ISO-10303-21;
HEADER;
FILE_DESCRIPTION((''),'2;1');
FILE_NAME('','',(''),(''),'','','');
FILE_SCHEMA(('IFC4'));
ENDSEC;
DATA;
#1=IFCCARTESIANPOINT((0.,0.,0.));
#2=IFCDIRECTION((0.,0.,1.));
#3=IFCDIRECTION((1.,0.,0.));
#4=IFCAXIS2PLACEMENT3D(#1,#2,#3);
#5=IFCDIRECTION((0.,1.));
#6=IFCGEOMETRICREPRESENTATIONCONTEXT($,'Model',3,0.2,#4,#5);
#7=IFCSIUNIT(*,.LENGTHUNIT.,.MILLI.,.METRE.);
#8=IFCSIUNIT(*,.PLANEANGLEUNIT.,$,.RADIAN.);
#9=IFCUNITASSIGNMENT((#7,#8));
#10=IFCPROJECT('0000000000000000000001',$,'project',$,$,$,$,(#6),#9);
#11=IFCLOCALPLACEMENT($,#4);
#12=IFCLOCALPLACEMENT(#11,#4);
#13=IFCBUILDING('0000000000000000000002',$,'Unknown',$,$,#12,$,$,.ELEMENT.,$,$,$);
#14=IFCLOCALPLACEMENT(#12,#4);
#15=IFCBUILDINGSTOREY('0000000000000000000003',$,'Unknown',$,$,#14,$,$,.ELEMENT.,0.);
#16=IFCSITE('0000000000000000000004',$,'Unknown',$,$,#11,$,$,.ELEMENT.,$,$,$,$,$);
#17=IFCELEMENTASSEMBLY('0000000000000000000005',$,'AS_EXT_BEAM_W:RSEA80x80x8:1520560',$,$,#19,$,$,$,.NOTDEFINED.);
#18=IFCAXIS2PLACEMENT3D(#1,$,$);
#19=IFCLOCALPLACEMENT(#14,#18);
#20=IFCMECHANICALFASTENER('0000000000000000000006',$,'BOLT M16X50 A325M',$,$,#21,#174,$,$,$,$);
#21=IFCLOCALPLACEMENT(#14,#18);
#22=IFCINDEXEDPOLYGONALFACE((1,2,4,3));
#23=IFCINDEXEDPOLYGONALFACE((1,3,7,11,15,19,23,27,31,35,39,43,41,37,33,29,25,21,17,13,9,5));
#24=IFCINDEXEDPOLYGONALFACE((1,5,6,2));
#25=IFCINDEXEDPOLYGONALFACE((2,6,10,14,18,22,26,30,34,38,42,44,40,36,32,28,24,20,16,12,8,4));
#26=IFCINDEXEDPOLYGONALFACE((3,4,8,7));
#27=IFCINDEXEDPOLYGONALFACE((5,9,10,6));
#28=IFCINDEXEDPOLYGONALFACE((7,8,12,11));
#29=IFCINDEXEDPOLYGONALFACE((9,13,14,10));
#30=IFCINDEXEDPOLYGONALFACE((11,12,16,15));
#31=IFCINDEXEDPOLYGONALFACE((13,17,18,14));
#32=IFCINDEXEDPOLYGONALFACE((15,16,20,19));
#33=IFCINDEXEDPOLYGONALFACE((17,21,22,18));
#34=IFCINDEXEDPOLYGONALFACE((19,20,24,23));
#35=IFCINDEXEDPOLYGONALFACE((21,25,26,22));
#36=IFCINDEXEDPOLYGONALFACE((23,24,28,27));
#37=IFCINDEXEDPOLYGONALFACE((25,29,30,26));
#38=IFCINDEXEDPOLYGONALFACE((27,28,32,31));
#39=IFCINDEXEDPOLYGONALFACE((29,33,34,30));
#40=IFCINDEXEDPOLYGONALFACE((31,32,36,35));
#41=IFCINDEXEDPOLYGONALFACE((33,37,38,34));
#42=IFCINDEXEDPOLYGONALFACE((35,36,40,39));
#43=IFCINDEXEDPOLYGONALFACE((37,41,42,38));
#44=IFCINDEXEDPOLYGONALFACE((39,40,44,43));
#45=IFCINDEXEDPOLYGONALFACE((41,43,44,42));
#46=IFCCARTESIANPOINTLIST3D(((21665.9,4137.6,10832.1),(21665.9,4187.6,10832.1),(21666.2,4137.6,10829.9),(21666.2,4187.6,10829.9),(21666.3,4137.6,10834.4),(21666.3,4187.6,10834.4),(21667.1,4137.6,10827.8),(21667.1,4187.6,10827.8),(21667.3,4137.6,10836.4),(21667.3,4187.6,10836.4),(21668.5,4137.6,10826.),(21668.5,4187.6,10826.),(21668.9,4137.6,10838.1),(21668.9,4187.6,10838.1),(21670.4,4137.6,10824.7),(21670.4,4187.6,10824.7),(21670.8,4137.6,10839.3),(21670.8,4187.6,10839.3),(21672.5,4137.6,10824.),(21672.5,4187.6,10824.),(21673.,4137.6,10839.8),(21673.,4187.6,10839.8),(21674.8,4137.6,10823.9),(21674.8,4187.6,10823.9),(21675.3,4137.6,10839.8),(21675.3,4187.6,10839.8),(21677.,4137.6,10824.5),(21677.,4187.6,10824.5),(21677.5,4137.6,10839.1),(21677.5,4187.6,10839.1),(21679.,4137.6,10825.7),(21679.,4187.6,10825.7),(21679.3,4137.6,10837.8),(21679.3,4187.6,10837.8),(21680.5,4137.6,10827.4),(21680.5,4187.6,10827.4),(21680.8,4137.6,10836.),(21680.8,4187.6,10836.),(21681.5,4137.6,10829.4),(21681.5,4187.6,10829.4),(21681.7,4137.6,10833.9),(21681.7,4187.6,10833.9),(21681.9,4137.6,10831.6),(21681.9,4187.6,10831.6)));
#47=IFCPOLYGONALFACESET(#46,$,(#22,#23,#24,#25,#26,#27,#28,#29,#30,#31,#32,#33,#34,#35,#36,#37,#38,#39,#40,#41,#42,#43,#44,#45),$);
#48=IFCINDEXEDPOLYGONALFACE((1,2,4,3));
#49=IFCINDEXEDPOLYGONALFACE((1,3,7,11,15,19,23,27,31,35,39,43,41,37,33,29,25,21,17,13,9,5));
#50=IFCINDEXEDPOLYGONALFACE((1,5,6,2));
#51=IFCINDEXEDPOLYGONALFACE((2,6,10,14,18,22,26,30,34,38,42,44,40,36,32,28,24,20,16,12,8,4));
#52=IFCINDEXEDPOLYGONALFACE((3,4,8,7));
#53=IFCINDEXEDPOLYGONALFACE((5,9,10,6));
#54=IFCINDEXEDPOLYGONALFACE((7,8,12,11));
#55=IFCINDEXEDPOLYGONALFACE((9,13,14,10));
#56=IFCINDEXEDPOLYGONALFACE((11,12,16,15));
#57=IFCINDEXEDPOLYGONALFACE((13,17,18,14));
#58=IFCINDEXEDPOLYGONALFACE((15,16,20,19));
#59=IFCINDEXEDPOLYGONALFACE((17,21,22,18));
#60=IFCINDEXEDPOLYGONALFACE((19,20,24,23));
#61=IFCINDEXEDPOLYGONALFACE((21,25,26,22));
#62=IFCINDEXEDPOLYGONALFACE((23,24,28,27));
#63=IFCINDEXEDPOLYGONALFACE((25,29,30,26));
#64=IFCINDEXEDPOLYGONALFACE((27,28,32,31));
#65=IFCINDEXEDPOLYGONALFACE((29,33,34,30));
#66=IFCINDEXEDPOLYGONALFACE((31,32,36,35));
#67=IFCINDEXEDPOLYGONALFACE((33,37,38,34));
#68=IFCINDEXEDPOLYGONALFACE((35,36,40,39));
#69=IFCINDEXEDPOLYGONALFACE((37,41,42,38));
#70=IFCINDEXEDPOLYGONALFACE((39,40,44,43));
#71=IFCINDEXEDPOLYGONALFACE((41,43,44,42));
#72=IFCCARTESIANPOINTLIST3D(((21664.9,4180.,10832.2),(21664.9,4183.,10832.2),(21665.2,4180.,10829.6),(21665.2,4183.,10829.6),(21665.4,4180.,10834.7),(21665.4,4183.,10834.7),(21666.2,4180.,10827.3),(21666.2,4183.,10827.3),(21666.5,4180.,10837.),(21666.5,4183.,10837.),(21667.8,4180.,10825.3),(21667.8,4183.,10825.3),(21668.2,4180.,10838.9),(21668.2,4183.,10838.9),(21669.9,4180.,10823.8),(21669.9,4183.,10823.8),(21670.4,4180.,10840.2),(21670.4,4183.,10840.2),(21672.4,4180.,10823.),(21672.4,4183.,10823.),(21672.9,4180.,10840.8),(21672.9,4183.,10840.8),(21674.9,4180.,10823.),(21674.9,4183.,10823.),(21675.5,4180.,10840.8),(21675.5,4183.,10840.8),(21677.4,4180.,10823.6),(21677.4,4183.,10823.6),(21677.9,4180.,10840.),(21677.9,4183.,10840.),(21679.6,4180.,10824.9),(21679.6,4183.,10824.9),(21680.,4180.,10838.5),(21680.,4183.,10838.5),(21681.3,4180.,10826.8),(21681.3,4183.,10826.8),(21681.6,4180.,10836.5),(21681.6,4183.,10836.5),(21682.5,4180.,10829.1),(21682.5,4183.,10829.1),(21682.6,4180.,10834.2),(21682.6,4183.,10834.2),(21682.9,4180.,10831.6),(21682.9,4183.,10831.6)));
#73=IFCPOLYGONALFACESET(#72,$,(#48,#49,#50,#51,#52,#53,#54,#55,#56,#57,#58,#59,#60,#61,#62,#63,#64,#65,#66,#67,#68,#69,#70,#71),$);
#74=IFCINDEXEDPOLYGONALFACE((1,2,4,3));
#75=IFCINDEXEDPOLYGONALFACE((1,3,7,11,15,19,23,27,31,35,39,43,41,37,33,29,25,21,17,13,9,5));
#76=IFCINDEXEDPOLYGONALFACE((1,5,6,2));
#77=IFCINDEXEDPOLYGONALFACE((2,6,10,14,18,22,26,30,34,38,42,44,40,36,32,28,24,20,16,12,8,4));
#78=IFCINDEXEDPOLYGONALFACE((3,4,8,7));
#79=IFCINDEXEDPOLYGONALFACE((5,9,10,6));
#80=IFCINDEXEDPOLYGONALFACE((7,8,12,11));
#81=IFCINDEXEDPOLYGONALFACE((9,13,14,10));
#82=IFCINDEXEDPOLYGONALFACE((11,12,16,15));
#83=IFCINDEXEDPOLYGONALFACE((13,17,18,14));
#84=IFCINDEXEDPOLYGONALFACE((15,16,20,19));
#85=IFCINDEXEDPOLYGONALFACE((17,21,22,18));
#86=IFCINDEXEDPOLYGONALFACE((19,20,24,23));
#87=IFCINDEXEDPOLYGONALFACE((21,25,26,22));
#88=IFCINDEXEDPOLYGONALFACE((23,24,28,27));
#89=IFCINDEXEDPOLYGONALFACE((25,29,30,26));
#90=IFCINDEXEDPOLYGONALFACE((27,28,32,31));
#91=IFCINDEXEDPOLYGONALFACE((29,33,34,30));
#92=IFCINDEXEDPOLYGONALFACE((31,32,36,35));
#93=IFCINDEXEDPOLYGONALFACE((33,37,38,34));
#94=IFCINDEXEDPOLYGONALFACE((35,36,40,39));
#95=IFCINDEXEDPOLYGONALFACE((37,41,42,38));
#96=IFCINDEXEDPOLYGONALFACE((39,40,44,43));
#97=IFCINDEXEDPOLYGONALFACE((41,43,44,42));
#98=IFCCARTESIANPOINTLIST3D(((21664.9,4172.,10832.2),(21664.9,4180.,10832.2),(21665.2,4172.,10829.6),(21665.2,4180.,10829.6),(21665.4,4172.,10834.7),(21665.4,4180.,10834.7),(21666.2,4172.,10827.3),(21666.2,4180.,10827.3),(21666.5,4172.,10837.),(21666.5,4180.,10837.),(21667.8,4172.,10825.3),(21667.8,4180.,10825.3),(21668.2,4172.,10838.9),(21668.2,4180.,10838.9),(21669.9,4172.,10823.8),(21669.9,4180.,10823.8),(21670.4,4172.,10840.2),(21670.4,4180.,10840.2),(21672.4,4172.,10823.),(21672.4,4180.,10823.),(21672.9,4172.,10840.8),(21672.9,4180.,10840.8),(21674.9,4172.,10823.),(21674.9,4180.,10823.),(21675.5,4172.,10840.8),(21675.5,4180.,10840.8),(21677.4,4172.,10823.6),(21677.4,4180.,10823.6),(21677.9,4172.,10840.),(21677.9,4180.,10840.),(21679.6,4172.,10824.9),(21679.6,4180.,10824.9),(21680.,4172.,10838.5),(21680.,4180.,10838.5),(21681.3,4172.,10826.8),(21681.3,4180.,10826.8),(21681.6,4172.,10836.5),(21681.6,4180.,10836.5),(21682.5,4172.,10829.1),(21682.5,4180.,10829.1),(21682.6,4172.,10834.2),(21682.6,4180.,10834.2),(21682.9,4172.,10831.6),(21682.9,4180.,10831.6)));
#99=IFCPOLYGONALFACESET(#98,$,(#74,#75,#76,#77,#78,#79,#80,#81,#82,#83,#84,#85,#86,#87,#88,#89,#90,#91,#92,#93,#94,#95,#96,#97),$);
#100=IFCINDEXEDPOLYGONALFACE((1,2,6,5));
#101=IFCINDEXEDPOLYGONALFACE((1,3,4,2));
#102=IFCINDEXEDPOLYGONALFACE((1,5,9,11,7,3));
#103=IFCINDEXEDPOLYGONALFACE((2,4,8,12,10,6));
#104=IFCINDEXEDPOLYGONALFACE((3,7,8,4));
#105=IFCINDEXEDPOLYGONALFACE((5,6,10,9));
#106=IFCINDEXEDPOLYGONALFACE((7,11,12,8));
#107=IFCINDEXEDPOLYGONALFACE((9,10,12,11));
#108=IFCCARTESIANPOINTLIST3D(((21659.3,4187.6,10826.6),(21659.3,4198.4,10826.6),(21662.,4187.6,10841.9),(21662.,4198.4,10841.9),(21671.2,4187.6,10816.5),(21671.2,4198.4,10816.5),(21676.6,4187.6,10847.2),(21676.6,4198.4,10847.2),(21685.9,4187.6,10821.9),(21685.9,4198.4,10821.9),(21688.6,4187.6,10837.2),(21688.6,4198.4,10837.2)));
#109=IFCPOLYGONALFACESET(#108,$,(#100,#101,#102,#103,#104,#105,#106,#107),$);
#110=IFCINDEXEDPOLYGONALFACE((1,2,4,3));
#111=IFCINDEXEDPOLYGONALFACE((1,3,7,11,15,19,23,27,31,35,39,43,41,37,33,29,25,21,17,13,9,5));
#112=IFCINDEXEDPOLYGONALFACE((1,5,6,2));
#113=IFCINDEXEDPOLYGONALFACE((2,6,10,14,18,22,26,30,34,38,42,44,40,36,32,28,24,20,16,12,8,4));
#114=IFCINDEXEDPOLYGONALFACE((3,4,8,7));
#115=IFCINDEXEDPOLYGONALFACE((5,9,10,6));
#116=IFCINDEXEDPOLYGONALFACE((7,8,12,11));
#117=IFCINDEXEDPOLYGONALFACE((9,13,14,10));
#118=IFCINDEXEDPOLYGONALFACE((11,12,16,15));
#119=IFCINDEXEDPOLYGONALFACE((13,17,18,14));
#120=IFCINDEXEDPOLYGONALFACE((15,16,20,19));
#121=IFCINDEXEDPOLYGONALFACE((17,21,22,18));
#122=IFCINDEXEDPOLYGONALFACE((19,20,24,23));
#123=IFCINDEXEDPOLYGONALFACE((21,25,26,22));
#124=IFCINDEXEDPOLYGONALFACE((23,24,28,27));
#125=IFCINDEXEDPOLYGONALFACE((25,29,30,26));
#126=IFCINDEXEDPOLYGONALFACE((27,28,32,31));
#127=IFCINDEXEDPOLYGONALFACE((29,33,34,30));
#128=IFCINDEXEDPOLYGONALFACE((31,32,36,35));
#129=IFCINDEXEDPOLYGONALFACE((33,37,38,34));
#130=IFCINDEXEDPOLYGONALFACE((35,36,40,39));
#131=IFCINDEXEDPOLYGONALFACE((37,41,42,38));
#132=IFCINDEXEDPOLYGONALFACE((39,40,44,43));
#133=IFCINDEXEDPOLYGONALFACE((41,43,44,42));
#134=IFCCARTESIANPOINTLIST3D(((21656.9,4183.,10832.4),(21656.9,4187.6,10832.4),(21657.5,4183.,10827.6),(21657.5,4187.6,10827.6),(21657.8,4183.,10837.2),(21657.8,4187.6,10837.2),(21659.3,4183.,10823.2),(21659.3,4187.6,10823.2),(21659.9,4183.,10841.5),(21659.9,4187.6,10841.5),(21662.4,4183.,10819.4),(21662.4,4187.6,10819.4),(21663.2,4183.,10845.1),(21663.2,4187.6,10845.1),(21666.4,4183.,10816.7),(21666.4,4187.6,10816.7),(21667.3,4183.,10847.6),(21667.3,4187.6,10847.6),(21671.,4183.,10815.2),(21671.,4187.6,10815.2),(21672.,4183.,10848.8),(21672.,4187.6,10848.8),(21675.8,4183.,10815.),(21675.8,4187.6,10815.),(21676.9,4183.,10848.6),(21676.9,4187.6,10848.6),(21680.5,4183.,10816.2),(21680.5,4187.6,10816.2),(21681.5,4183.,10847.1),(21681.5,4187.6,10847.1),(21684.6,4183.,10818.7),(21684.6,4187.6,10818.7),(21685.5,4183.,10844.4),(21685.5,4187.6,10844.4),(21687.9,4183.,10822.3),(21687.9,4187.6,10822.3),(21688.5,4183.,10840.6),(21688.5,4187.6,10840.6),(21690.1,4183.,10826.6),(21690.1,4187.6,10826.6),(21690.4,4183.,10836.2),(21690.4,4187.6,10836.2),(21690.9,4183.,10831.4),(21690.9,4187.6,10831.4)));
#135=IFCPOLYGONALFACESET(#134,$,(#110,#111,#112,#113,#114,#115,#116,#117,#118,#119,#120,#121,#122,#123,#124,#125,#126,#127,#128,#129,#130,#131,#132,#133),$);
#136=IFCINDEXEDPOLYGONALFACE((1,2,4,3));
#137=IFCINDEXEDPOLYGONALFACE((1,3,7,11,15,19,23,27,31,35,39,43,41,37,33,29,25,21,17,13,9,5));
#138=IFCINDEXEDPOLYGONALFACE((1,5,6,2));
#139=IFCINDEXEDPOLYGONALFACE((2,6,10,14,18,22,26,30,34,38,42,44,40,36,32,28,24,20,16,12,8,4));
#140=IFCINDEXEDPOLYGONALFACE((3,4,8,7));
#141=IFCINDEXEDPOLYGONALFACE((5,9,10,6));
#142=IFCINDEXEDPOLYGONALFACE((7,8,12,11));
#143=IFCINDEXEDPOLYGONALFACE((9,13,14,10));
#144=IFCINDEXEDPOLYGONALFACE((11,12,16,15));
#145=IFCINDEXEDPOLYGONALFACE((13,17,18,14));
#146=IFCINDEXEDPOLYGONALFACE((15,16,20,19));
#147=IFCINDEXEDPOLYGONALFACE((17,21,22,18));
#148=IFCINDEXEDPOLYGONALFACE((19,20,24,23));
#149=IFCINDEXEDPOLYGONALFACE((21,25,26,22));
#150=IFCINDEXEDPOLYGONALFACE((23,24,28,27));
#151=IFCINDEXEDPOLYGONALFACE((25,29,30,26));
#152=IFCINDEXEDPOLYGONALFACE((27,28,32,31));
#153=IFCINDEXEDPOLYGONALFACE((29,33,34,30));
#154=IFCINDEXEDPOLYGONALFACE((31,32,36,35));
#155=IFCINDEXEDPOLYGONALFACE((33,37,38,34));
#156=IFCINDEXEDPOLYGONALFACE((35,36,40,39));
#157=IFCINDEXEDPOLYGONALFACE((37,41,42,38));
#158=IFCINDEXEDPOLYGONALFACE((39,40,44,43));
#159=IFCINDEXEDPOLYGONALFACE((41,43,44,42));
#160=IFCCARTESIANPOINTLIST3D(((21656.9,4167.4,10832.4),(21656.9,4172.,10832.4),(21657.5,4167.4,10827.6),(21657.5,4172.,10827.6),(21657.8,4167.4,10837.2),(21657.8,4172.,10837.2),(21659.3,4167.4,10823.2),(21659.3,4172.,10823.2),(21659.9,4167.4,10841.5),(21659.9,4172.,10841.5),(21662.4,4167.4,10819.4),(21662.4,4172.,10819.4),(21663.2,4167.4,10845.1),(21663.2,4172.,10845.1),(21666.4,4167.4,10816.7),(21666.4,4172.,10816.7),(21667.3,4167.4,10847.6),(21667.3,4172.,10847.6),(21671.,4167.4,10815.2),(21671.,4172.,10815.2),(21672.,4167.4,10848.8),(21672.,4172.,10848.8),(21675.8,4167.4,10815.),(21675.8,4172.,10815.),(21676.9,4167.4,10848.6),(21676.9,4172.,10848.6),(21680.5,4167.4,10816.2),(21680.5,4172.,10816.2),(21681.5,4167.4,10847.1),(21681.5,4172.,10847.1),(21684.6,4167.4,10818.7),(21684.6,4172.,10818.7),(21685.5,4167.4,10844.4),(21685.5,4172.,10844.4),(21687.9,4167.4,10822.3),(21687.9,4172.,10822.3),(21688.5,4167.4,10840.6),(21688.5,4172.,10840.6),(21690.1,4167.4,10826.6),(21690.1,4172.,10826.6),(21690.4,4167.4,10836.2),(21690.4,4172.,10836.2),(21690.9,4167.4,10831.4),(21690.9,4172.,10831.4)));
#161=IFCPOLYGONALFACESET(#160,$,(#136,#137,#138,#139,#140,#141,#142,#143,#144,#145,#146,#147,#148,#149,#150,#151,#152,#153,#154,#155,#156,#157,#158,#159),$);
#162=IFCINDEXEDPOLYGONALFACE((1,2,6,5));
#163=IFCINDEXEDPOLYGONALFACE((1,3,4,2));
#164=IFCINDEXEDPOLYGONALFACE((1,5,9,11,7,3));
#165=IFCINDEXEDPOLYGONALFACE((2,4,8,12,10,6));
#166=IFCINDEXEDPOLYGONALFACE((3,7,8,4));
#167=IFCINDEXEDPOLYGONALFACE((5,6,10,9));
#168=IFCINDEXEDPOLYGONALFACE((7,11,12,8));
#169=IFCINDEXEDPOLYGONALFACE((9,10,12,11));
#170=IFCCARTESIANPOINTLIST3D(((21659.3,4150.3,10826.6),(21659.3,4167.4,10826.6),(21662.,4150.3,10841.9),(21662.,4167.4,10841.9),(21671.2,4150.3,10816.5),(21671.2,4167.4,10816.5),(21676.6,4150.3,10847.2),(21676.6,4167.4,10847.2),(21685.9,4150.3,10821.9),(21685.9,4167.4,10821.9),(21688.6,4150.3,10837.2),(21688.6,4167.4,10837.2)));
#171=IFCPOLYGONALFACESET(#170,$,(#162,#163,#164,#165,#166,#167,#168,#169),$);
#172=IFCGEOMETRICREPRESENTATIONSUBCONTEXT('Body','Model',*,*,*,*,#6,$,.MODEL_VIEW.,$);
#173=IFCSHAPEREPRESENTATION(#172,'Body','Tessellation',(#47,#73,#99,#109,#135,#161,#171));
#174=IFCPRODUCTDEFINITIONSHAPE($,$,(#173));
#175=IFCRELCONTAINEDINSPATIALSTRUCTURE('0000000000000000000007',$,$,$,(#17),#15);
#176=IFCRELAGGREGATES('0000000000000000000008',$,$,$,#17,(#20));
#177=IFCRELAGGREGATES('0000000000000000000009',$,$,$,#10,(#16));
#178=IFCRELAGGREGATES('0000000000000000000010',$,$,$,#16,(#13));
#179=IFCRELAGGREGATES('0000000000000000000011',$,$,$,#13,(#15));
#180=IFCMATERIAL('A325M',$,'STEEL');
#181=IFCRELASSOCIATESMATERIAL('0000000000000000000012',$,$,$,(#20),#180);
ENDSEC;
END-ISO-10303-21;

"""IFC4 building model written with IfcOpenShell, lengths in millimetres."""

from ifc_helpers import new_model, si_unit, direction, frame, origin_with_axes, place, context, subcontext, project, spatial, line, arc, indexed_curve, outline, extrude, source, transform, mapped, material, element, aggregate, save


model = new_model("IFC4")

# Units and contexts
model_context = context("Model", 3, precision=0.2, world=origin_with_axes(), true_north=direction((0.0, 1.0)))
body_context = subcontext(model_context, "Body", "Model", "MODEL_VIEW")
ifc_project = project(units=[si_unit("LENGTHUNIT", "METRE", prefix="MILLI"), si_unit("PLANEANGLEUNIT", "RADIAN")], contexts=[model_context])

# Site, building, storey
site_placement = place(None, origin_with_axes())
site = spatial("IfcSite", under=ifc_project, at=site_placement, Name="Unknown", CompositionType="ELEMENT")
building_placement = place(site_placement, origin_with_axes())
building = spatial("IfcBuilding", under=site, at=building_placement, Name="Unknown", CompositionType="ELEMENT")
storey_placement = place(building_placement, origin_with_axes())
storey = spatial("IfcBuildingStorey", under=building, at=storey_placement, Name="Unknown", CompositionType="ELEMENT", Elevation=0.0)

# Shared definitions
ifc_material_1 = material(Name="A325M", Category="STEEL")
shared_shape = source(origin_with_axes(), body_context, "Body", "SweptSolid", [
    extrude(outline(indexed_curve([(8.0, 0.0), (0.0, 8.0), (-8.0, 0.0), (0.0, -8.0)], segments=[arc(1, 2, 3), arc(3, 4, 1)])), frame((0.0, 0.0, 15.6), z_axis=(0.0, 0.0, -1.0), x_axis=(0.0, 1.0, 0.0)), (0.0, 0.0, 1.0), 50.0),
    extrude(outline(indexed_curve([(9.0, 0.0), (0.0, 9.0), (-9.0, 0.0), (0.0, -9.0)], segments=[arc(1, 2, 3), arc(3, 4, 1)])), frame((0.0, 0.0, 11.0), z_axis=(0.0, 0.0, -1.0), x_axis=(0.0, 1.0, 0.0)), (0.0, 0.0, 1.0), 3.0),
    extrude(outline(indexed_curve([(9.0, 0.0), (0.0, 9.0), (-9.0, 0.0), (0.0, -9.0)], segments=[arc(1, 2, 3), arc(3, 4, 1)])), frame((0.0, 0.0, 8.0), z_axis=(0.0, 0.0, -1.0), x_axis=(0.0, 1.0, 0.0)), (0.0, 0.0, 1.0), 8.0),
    extrude(outline(indexed_curve([(15.6, 0.0), (7.8, 13.5), (-7.8, 13.5), (-15.6, 0.0), (-7.8, -13.5), (7.8, -13.5)], segments=[line(1, 2, 3, 4, 5, 6, 1)])), frame((0.0, 0.0, 26.4), z_axis=(0.0, 0.0, -1.0), x_axis=(0.0, 1.0, 0.0)), (0.0, 0.0, 1.0), 10.8),
    extrude(outline(indexed_curve([(17.0, 0.0), (0.0, 17.0), (-17.0, 0.0), (0.0, -17.0)], segments=[arc(1, 2, 3), arc(3, 4, 1)])), frame((0.0, 0.0, 15.6), z_axis=(0.0, 0.0, -1.0), x_axis=(0.0, 1.0, 0.0)), (0.0, 0.0, 1.0), 4.6),
    extrude(outline(indexed_curve([(17.0, 0.0), (0.0, 17.0), (-17.0, 0.0), (0.0, -17.0)], segments=[arc(1, 2, 3), arc(3, 4, 1)])), frame((0.0, 0.0, 0.0), z_axis=(0.0, 0.0, -1.0), x_axis=(0.0, 1.0, 0.0)), (0.0, 0.0, 1.0), 4.6),
    extrude(outline(indexed_curve([(15.6, 0.0), (7.8, 13.5), (-7.8, 13.5), (-15.6, 0.0), (-7.8, -13.5), (7.8, -13.5)], segments=[line(1, 2, 3, 4, 5, 6, 1)])), frame((0.0, 0.0, -4.6), z_axis=(0.0, 0.0, -1.0), x_axis=(0.0, 1.0, 0.0)), (0.0, 0.0, 1.0), 17.1),
])

# Element assembly, mechanical fastener
assembly_1_placement = place(storey_placement, frame((21611.5, 4140.0, 10837.8), z_axis=(0.0, -1.0, 0.0), x_axis=(0.984808, 0.0, -0.173648)))
assembly_1 = element("IfcElementAssembly", 1, at=assembly_1_placement, inside=storey, Name="AS_EXT_BEAM_W:RSEA80x80x8:1520560", PredefinedType="NOTDEFINED")
mechanical_fastener_1_placement = place(assembly_1_placement, frame((62.5, 5.0, -32.0), z_axis=(0.0, 0.0, -1.0), x_axis=(1.0, 0.0, 0.0)))
mechanical_fastener_1 = element("IfcMechanicalFastener", 2, at=mechanical_fastener_1_placement, material=ifc_material_1, Name="BOLT M16X50 A325M", context=body_context, shape_type="MappedRepresentation", body=[
    mapped(shared_shape, transform((0.0, 0.0, 0.0))),
])
aggregate(assembly_1, [mechanical_fastener_1])

save(model, "model.ifc")
